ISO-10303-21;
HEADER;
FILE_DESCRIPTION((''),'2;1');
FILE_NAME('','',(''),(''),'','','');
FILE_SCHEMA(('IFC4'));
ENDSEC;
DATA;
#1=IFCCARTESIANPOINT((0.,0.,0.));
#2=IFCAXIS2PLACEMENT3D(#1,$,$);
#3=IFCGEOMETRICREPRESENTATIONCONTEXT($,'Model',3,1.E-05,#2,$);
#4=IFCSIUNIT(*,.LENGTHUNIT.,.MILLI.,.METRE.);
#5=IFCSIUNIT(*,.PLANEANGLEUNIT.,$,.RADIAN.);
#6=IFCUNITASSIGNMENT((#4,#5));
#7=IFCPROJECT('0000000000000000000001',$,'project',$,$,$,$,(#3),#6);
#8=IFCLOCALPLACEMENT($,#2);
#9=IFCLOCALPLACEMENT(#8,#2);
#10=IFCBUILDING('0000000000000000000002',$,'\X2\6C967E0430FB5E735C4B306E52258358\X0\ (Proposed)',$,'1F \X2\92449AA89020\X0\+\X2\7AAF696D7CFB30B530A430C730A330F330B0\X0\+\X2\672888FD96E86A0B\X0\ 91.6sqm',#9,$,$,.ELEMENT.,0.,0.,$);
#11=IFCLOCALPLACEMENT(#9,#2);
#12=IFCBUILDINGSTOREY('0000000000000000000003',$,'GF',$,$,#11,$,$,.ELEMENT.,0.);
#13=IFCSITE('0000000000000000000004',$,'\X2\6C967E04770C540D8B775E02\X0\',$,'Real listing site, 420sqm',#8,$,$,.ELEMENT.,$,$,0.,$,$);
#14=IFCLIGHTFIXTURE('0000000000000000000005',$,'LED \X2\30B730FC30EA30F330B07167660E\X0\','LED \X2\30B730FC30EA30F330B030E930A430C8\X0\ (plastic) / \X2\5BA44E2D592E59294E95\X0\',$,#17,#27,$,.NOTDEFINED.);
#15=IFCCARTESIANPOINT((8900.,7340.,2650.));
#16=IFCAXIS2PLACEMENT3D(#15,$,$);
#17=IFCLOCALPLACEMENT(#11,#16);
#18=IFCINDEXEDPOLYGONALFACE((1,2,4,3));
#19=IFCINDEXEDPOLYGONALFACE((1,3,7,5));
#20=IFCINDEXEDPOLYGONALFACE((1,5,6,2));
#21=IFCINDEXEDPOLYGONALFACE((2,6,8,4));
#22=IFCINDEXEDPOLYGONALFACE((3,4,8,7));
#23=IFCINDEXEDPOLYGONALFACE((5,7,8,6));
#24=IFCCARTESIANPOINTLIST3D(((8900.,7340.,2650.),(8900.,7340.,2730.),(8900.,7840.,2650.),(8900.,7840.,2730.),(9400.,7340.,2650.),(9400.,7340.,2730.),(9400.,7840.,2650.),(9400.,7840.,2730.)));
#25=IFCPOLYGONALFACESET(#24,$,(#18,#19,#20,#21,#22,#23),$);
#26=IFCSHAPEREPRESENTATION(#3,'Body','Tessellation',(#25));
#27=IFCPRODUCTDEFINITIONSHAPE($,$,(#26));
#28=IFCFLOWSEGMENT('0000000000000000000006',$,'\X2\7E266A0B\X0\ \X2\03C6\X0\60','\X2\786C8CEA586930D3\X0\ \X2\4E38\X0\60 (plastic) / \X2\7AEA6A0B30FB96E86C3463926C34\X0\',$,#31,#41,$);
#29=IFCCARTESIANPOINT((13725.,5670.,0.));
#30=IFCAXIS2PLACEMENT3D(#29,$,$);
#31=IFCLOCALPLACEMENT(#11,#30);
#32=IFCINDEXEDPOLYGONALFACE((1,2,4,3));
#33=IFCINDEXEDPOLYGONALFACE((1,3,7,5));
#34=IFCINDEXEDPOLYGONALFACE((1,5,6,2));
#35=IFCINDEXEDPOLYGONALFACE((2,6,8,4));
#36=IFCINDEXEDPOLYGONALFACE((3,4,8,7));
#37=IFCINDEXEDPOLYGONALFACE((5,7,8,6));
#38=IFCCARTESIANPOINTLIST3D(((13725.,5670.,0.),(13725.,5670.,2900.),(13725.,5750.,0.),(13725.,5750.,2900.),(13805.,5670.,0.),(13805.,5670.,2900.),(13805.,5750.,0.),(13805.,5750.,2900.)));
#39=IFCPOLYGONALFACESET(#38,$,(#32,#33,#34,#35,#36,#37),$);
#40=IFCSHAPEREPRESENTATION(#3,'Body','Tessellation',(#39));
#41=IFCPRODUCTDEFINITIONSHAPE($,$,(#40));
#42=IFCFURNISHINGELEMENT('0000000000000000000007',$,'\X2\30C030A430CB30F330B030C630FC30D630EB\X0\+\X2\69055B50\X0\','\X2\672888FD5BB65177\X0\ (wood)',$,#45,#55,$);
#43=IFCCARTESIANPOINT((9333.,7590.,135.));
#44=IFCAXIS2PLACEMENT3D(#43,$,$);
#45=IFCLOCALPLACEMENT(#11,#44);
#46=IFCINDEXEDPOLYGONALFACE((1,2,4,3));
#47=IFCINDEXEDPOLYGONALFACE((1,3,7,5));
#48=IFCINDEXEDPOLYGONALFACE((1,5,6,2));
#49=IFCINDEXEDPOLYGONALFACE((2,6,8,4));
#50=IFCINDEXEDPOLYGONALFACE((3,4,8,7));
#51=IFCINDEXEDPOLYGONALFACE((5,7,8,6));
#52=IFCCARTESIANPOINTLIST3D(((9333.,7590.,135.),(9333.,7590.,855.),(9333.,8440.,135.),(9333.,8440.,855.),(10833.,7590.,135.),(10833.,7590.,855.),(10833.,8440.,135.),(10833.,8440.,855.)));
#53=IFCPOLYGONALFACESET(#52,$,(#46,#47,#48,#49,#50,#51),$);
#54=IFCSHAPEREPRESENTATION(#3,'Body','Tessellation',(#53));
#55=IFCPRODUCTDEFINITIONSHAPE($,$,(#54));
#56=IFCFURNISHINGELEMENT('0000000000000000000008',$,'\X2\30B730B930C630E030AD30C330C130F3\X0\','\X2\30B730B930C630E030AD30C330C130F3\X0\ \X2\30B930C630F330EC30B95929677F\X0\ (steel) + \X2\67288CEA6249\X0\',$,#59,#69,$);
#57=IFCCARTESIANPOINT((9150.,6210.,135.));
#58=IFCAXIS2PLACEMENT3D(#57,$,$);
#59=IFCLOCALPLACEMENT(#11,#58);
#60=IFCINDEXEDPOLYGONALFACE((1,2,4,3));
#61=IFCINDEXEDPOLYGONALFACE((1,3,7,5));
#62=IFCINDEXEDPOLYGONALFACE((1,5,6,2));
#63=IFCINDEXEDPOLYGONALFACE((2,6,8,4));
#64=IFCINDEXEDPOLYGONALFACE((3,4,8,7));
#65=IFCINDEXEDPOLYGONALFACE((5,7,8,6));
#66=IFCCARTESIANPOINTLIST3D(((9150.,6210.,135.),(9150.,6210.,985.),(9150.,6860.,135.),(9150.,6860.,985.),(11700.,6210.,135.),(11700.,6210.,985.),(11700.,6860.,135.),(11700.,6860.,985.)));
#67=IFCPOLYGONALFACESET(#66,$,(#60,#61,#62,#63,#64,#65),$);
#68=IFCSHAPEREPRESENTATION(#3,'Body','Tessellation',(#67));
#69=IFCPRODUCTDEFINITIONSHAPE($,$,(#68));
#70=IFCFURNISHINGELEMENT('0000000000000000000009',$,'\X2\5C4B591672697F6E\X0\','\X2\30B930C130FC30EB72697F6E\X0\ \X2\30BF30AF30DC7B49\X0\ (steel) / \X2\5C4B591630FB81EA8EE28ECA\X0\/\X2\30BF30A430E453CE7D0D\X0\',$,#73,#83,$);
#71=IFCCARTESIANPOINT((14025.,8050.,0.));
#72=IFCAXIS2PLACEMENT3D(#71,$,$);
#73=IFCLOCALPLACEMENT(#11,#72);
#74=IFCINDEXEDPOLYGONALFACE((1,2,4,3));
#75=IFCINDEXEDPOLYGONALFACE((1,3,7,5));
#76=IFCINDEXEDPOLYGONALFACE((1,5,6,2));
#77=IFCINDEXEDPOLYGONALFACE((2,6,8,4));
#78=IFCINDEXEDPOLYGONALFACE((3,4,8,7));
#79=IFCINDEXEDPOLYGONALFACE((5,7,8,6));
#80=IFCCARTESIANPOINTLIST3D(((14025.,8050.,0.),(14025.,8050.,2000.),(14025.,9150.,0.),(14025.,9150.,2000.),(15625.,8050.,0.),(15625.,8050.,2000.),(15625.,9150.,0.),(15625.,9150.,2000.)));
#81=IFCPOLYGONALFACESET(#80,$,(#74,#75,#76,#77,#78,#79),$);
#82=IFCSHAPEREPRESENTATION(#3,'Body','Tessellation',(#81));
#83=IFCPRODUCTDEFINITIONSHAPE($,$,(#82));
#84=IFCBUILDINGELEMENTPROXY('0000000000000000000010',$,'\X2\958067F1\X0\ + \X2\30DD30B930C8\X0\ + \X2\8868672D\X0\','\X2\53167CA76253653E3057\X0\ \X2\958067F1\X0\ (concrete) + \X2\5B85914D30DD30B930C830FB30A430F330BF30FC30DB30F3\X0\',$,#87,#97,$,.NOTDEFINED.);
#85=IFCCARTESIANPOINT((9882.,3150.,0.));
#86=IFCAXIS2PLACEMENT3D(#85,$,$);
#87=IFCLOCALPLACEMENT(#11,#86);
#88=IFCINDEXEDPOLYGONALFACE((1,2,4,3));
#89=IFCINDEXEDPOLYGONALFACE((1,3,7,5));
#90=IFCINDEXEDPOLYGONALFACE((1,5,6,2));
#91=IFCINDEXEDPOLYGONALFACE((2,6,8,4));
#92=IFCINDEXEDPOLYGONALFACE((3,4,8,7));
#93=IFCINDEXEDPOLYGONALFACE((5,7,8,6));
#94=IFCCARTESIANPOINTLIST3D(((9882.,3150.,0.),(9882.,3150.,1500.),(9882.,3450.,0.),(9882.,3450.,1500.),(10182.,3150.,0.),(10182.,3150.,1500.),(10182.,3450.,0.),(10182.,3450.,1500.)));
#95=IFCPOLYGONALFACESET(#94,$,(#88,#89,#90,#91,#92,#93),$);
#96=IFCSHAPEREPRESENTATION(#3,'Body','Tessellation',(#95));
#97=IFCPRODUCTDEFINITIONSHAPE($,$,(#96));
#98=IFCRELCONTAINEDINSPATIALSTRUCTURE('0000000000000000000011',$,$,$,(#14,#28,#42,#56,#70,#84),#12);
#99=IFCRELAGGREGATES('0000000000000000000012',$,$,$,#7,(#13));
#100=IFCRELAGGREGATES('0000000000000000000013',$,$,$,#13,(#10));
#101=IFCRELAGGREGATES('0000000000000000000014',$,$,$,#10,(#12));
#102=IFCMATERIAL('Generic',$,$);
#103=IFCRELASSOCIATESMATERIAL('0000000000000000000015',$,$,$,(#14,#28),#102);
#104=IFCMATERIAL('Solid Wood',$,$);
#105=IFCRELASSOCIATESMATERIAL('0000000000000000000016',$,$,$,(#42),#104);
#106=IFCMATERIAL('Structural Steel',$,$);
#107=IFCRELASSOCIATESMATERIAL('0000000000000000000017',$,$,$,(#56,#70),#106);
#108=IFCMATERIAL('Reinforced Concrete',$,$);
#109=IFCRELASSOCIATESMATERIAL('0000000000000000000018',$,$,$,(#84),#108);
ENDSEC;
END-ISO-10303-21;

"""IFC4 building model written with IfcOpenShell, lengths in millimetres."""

from ifc_helpers import new_model, si_unit, frame, frame_2d, origin, place, context, project, spatial, rectangle, extrude, material, element, save


model = new_model("IFC4")

# Units and contexts
model_context = context("Model", 3, precision=1e-05, world=origin())
ifc_project = project(units=[si_unit("LENGTHUNIT", "METRE", prefix="MILLI"), si_unit("PLANEANGLEUNIT", "RADIAN")], contexts=[model_context])

# Site, building, storey
site_placement = place(None, origin())
site = spatial("IfcSite", under=ifc_project, at=site_placement, Name="沖縄県名護市", ObjectType="Real listing site, 420sqm", CompositionType="ELEMENT", RefElevation=0.0)
building_placement = place(site_placement, origin())
building = spatial("IfcBuilding", under=site, at=building_placement, Name="沖縄・平屋の別荘 (Proposed)", ObjectType="1F 鉄骨造+窯業系サイディング+木製雨樋 91.6sqm", CompositionType="ELEMENT", ElevationOfRefHeight=0.0, ElevationOfTerrain=0.0)
storey_placement = place(building_placement, origin())
storey = spatial("IfcBuildingStorey", under=building, at=storey_placement, Name="GF", CompositionType="ELEMENT", Elevation=0.0)

# Shared definitions
ifc_material_1 = material(Name="Solid Wood")

# Shared definitions
ifc_material_2 = material(Name="Structural Steel")

# Shared definitions
ifc_material_3 = material(Name="Reinforced Concrete")

# Shared definitions
ifc_material_4 = material(Name="Generic")

# Light fixture
light_fixture_placement = place(storey_placement, frame((8900.0, 7340.0, 2650.0)))
element("IfcLightFixture", 1, at=light_fixture_placement, inside=storey, material=ifc_material_4, Name="LED シーリング照明", Description="LED シーリングライト (plastic) / 室中央天井", PredefinedType="NOTDEFINED", context=model_context, shape_type="SweptSolid", body=[
    extrude(rectangle(XDim=500.0, YDim=500.0, at=frame_2d((250.0, 250.0))), frame((8900.0, 7340.0, 2650.0)), (0.0, 0.0, 1.0), 80.0),
])

# Flow segment
flow_segment_placement = place(storey_placement, frame((13725.0, 5670.0, 0.0)))
element("IfcFlowSegment", 2, at=flow_segment_placement, inside=storey, material=ifc_material_4, Name="縦樋 φ60", Description="硬質塩ビ 丸60 (plastic) / 竪樋・雨水排水", context=model_context, shape_type="SweptSolid", body=[
    extrude(rectangle(XDim=80.0, YDim=80.0, at=frame_2d((40.0, 40.0))), frame((13725.0, 5670.0, 0.0)), (0.0, 0.0, 1.0), 2900.0),
])

# Furnishing elements
furnishing_1_placement = place(storey_placement, frame((9333.0, 7590.0, 135.0)))
element("IfcFurnishingElement", 3, at=furnishing_1_placement, inside=storey, material=ifc_material_1, Name="ダイニングテーブル+椅子", Description="木製家具 (wood)", context=model_context, shape_type="SweptSolid", body=[
    extrude(rectangle(XDim=1500.0, YDim=850.0, at=frame_2d((750.0, 425.0))), frame((9333.0, 7590.0, 135.0)), (0.0, 0.0, 1.0), 720.0),
])
furnishing_2_placement = place(storey_placement, frame((9150.0, 6210.0, 135.0)))
element("IfcFurnishingElement", 4, at=furnishing_2_placement, inside=storey, material=ifc_material_2, Name="システムキッチン", Description="システムキッチン ステンレス天板 (steel) + 木質扉", context=model_context, shape_type="SweptSolid", body=[
    extrude(rectangle(XDim=2550.0, YDim=650.0, at=frame_2d((1275.0, 325.0))), frame((9150.0, 6210.0, 135.0)), (0.0, 0.0, 1.0), 850.0),
])
furnishing_3_placement = place(storey_placement, frame((14025.0, 8050.0, 0.0)))
element("IfcFurnishingElement", 5, at=furnishing_3_placement, inside=storey, material=ifc_material_2, Name="屋外物置", Description="スチール物置 タクボ等 (steel) / 屋外・自転車/タイヤ収納", context=model_context, shape_type="SweptSolid", body=[
    extrude(rectangle(XDim=1600.0, YDim=1100.0, at=frame_2d((800.0, 550.0))), frame((14025.0, 8050.0, 0.0)), (0.0, 0.0, 1.0), 2000.0),
])

# Building element proxy
proxy_placement = place(storey_placement, frame((9882.0, 3150.0, 0.0)))
element("IfcBuildingElementProxy", 6, at=proxy_placement, inside=storey, material=ifc_material_3, Name="門柱 + ポスト + 表札", Description="化粧打放し 門柱 (concrete) + 宅配ポスト・インターホン", PredefinedType="NOTDEFINED", context=model_context, shape_type="SweptSolid", body=[
    extrude(rectangle(XDim=300.0, YDim=300.0, at=frame_2d((150.0, 150.0))), frame((9882.0, 3150.0, 0.0)), (0.0, 0.0, 1.0), 1500.0),
])

save(model, "model.ifc")
